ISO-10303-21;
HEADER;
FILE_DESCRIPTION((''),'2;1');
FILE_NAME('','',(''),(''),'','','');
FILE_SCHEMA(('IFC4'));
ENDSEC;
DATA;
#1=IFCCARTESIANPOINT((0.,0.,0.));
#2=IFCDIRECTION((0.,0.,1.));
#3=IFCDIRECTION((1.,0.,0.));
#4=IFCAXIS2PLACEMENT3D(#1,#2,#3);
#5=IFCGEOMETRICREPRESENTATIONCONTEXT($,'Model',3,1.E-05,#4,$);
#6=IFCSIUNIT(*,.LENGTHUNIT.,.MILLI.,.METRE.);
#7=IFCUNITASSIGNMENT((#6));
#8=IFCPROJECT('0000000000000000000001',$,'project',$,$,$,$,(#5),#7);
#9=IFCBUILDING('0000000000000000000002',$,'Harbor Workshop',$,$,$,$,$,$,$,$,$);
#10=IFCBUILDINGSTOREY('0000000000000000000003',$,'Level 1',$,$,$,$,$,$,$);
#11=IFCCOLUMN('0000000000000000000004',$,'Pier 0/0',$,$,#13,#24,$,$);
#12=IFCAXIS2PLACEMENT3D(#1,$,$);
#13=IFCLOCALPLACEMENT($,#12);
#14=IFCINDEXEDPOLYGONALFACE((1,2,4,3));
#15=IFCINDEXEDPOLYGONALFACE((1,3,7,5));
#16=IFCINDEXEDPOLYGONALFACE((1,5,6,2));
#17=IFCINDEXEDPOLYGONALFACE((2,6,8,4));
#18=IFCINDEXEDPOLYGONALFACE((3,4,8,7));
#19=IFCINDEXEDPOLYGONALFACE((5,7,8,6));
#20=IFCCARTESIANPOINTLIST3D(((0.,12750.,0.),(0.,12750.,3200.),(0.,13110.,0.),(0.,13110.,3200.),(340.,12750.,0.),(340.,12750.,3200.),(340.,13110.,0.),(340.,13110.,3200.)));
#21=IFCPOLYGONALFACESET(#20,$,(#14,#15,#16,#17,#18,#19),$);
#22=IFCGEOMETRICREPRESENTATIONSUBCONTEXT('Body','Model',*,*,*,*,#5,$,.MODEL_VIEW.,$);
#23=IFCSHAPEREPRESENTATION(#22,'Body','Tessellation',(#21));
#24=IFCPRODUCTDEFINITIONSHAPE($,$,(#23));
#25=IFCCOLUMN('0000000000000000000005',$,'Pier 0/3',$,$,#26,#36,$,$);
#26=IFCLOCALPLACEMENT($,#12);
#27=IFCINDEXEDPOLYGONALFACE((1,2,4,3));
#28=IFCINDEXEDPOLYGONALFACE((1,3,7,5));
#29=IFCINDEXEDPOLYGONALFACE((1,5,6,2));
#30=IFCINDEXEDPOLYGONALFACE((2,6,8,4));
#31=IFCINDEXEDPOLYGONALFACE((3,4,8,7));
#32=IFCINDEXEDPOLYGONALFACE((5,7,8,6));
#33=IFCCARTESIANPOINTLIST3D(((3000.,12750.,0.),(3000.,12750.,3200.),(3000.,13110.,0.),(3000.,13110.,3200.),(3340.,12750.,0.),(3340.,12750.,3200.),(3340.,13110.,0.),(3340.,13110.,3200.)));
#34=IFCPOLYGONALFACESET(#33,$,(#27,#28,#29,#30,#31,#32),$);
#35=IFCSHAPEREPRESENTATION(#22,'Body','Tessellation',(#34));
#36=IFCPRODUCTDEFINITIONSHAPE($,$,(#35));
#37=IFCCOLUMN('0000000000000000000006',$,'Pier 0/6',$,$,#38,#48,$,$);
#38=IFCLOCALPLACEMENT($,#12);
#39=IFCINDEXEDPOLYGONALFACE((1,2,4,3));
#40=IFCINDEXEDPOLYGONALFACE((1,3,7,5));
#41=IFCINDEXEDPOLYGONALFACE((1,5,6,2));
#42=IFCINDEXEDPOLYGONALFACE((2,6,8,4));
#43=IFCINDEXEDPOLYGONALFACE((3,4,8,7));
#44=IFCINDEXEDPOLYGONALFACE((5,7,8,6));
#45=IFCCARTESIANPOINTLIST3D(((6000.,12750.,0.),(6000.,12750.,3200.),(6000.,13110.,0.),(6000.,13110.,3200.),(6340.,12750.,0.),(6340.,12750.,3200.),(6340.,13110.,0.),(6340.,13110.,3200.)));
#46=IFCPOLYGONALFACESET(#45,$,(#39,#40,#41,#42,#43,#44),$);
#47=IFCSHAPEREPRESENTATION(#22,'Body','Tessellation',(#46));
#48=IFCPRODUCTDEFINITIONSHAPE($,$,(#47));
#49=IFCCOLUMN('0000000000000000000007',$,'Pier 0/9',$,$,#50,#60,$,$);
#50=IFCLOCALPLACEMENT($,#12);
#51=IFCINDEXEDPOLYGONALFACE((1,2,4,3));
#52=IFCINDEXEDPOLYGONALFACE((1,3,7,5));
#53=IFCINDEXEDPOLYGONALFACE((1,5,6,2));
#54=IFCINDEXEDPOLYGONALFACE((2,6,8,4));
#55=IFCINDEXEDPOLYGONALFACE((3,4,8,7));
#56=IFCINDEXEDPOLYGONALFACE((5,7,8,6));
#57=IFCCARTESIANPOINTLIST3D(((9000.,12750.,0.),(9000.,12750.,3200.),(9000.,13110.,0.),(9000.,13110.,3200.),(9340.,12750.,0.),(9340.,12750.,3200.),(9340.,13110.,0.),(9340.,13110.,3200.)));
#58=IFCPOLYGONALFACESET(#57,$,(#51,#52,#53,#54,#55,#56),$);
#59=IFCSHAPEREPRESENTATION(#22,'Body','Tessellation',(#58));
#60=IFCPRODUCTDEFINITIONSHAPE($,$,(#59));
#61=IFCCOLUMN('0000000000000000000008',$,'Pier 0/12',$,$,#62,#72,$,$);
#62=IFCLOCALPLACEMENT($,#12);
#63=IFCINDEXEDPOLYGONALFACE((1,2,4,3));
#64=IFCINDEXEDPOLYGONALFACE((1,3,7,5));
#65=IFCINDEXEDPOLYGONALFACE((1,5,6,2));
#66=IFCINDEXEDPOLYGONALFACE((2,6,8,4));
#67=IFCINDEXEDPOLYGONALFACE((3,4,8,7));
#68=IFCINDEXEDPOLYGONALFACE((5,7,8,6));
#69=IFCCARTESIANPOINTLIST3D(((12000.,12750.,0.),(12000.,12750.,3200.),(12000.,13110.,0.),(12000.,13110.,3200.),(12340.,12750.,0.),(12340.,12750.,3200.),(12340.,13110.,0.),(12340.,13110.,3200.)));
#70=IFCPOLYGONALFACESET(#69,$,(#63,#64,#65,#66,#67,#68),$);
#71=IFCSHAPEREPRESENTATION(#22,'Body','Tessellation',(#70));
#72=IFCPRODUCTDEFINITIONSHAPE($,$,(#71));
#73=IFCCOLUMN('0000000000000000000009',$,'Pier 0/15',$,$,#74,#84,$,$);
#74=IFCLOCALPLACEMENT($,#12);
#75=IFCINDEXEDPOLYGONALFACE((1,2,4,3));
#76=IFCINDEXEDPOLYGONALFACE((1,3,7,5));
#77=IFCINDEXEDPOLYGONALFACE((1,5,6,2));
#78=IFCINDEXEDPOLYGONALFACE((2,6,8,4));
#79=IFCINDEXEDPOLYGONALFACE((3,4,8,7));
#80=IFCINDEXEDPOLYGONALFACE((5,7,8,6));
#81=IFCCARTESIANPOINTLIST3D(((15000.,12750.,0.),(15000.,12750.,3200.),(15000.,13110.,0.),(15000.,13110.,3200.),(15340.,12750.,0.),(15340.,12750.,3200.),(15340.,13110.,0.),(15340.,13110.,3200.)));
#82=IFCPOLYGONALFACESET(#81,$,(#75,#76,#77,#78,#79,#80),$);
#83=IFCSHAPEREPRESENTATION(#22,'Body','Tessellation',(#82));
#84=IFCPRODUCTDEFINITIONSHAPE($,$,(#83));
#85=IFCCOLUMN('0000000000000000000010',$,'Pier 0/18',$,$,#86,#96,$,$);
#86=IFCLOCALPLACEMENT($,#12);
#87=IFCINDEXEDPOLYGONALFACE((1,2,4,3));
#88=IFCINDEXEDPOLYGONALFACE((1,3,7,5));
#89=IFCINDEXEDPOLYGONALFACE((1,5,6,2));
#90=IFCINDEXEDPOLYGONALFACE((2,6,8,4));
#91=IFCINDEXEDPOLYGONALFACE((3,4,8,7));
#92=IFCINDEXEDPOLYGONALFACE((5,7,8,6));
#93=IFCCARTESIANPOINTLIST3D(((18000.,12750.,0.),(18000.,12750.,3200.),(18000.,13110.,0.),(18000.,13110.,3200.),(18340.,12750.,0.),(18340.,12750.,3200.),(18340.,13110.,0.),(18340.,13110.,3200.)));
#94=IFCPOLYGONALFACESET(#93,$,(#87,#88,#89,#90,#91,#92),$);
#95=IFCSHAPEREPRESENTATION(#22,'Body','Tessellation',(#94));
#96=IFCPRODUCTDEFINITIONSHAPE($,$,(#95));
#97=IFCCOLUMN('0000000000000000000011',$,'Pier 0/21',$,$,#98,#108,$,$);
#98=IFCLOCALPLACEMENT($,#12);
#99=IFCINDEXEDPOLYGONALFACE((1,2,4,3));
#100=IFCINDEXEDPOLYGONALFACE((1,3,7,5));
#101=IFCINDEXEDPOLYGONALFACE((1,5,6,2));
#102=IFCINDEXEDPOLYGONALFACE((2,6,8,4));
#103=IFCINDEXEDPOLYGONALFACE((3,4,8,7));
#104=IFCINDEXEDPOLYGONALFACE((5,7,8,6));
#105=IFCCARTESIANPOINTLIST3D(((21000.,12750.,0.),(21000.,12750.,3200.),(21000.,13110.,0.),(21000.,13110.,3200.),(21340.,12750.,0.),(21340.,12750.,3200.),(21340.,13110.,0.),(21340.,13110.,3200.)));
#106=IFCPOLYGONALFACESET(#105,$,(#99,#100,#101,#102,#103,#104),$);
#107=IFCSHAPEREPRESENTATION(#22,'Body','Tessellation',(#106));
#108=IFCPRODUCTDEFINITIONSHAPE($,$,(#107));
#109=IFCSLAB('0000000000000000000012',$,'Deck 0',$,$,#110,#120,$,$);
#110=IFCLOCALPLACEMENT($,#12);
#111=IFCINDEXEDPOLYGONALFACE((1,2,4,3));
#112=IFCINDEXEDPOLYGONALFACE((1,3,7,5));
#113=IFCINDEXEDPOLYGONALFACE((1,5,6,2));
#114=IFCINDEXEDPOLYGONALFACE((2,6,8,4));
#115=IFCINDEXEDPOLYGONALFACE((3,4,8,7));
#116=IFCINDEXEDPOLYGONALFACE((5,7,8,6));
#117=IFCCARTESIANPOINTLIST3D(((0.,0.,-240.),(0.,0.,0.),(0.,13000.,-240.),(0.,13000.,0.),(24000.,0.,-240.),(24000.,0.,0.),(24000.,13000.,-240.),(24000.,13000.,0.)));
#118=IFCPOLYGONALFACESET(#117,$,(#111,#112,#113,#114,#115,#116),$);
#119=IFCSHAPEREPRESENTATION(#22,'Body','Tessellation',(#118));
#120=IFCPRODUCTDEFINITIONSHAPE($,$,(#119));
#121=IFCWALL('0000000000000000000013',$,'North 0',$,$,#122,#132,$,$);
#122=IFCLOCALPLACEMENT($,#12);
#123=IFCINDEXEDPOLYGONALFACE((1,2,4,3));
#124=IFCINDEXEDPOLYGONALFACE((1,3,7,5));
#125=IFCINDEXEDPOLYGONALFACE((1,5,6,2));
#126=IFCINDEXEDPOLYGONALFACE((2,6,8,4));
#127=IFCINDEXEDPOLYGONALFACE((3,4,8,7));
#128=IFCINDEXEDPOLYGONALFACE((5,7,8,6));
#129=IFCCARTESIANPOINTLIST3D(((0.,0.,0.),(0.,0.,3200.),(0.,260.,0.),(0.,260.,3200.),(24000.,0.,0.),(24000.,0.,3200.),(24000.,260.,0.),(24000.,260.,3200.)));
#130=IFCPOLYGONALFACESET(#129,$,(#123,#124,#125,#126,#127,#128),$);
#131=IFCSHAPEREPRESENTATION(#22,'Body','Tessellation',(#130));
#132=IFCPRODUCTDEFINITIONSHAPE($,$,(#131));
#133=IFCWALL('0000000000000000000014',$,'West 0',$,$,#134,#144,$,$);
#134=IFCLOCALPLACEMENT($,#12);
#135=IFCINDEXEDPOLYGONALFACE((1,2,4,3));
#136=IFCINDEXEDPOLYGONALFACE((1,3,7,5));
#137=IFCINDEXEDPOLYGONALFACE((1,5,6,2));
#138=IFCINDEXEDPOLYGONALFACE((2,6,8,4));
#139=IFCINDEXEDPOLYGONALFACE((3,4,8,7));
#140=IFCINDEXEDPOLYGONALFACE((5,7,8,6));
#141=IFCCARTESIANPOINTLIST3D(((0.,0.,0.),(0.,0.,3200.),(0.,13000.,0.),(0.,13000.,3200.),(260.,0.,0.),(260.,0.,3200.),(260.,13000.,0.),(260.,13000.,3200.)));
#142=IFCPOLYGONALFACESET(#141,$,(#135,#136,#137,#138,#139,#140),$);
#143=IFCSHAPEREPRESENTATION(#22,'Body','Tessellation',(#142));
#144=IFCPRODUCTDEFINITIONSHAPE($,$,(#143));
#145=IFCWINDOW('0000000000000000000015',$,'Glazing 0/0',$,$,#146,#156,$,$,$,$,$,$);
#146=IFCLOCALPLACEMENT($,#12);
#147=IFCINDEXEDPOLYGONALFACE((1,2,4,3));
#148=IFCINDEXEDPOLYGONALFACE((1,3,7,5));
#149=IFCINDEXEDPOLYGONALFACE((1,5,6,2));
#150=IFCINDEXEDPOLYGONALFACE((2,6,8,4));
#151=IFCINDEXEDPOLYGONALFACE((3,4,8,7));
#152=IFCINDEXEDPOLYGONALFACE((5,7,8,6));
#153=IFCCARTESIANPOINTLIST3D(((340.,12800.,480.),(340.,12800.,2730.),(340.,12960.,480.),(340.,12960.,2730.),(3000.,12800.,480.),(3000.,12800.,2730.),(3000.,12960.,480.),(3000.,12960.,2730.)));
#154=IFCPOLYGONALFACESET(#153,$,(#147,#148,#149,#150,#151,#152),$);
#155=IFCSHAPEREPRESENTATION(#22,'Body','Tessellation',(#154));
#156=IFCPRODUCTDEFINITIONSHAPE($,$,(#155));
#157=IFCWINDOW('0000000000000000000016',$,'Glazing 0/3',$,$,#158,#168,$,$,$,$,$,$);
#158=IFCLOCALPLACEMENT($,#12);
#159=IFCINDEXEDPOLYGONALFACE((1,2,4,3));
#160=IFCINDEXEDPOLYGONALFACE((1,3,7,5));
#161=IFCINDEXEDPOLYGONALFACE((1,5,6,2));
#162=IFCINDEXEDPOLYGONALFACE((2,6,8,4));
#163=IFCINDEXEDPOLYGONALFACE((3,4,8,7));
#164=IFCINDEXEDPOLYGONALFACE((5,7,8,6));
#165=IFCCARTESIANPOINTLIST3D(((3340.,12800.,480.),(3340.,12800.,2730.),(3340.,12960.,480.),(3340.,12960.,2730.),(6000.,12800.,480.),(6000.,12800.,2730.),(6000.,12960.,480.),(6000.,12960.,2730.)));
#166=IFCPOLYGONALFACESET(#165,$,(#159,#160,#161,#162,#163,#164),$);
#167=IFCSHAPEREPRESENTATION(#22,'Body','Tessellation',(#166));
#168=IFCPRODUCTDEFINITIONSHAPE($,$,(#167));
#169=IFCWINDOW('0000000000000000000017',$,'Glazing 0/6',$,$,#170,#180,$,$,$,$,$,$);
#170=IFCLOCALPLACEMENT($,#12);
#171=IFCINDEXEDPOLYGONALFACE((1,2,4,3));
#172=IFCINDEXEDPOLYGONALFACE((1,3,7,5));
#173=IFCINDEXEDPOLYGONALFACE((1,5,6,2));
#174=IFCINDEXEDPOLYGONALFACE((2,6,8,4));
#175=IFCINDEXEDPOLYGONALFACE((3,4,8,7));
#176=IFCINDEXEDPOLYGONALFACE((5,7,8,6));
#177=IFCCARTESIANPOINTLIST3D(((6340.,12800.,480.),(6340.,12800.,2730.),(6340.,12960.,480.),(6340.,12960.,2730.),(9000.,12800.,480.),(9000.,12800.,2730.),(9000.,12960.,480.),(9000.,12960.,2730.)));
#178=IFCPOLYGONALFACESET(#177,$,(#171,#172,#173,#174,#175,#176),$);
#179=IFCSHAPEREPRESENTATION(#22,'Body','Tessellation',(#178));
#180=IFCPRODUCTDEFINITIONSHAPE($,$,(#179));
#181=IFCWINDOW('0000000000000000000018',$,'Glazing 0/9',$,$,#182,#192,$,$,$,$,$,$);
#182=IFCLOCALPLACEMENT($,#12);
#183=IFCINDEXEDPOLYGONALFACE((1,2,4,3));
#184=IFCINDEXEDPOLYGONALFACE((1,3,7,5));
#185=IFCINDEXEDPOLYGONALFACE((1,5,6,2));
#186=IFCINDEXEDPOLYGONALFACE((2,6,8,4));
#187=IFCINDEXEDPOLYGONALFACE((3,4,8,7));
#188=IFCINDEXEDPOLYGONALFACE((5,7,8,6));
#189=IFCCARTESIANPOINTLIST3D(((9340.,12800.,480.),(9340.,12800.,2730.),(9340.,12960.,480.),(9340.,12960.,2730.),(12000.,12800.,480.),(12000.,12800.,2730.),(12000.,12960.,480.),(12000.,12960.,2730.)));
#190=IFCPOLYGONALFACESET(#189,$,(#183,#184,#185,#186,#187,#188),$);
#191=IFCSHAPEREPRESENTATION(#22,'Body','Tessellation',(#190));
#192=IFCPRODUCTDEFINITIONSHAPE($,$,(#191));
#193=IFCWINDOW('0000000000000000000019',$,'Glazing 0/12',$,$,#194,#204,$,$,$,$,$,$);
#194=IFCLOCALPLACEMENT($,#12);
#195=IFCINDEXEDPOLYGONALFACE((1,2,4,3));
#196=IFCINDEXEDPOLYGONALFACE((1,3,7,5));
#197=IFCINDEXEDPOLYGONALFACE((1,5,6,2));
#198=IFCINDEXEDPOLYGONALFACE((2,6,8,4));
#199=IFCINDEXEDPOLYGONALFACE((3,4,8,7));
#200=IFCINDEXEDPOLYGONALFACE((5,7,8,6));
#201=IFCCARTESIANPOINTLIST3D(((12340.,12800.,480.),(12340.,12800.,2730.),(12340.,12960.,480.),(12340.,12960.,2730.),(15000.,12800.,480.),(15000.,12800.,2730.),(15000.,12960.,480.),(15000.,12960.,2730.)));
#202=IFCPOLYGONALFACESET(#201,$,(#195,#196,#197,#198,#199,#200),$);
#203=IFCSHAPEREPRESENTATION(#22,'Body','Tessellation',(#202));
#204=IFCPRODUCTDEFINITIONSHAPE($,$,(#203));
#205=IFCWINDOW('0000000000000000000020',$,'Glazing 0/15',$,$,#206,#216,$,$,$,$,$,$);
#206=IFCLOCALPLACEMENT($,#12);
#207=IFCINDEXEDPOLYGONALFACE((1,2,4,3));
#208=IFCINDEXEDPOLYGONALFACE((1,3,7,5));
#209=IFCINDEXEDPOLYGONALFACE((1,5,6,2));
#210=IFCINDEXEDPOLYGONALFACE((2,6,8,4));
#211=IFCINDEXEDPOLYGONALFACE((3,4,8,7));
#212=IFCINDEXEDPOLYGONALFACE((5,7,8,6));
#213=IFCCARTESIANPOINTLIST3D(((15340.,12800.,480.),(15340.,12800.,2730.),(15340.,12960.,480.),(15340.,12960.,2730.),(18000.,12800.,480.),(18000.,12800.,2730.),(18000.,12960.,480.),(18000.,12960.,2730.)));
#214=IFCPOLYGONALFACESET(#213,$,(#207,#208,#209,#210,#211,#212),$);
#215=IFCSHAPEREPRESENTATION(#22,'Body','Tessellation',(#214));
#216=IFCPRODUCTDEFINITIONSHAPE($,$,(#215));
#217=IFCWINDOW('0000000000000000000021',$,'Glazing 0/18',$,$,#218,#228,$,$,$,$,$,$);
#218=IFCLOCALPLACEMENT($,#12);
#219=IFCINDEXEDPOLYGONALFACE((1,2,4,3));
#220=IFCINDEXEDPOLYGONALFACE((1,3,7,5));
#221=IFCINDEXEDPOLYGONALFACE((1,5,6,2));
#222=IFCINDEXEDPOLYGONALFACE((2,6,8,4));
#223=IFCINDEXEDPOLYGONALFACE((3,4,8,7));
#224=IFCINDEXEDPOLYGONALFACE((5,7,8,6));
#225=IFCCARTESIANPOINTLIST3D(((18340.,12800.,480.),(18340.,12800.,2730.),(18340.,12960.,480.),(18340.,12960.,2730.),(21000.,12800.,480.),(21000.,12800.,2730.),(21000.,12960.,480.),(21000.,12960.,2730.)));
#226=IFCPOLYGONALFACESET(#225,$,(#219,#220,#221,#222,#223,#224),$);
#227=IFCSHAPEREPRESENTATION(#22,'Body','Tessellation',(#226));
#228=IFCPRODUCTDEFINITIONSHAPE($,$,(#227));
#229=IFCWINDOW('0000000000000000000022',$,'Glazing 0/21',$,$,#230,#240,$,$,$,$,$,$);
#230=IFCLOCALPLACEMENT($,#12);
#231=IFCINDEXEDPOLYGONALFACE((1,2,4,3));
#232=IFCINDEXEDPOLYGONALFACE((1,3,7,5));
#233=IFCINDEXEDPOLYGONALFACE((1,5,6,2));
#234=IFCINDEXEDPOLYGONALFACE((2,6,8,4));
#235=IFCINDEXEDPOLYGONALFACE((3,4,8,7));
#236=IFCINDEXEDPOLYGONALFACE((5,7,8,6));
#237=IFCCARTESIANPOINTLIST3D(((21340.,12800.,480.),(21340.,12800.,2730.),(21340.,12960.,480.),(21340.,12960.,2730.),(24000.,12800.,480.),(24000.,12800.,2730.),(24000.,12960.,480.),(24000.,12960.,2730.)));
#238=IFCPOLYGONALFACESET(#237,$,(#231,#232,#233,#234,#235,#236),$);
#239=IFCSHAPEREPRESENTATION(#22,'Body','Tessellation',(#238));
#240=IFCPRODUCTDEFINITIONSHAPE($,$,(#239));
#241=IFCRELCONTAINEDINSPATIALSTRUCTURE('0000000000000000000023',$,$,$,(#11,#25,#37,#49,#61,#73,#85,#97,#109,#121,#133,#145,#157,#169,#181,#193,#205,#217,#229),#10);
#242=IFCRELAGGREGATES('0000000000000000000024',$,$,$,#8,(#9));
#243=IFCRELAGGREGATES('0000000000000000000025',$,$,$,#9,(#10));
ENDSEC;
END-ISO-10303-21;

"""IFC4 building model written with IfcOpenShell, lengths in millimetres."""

from ifc_helpers import new_model, si_unit, frame, origin_with_axes, place, context, subcontext, project, spatial, indexed_curve, outline, extrude, element, save


model = new_model("IFC4")

# Units and contexts
model_context = context("Model", 3, precision=1e-05, world=origin_with_axes())
body_context = subcontext(model_context, "Body", "Model", "MODEL_VIEW")
ifc_project = project(units=[si_unit("LENGTHUNIT", "METRE", prefix="MILLI")], contexts=[model_context])

# Building, storey
building = spatial("IfcBuilding", under=ifc_project, Name="Harbor Workshop")
storey = spatial("IfcBuildingStorey", under=building, Name="Level 1")

# Columns
for number, where, z_axis, x_axis, name in (
    (1, (0.0, 12750.0, 0.0), (0.0, 0.0, 1.0), (1.0, 0.0, 0.0), "Pier 0/0"),
    (2, (3000.0, 12750.0, 0.0), (0.0, 0.0, 1.0), (1.0, 0.0, 0.0), "Pier 0/3"),
    (3, (6000.0, 12750.0, 0.0), (0.0, 0.0, 1.0), (1.0, 0.0, 0.0), "Pier 0/6"),
    (4, (9000.0, 12750.0, 0.0), (0.0, 0.0, 1.0), (1.0, 0.0, 0.0), "Pier 0/9"),
    (5, (12000.0, 12750.0, 0.0), (0.0, 0.0, 1.0), (1.0, 0.0, 0.0), "Pier 0/12"),
    (6, (15000.0, 12750.0, 0.0), (0.0, 0.0, 1.0), (1.0, 0.0, 0.0), "Pier 0/15"),
    (7, (18000.0, 12750.0, 0.0), (0.0, 0.0, 1.0), (1.0, 0.0, 0.0), "Pier 0/18"),
    (8, (21000.0, 12750.0, 0.0), (0.0, 0.0, 1.0), (1.0, 0.0, 0.0), "Pier 0/21"),
):
    element("IfcColumn", number, at=place(None, frame(where, z_axis=z_axis, x_axis=x_axis)), inside=storey, Name=name, context=body_context, shape_type="SweptSolid", body=[
        extrude(outline(indexed_curve([(0.0, 0.0), (0.0, 360.0), (340.0, 360.0), (340.0, 0.0), (0.0, 0.0)], self_intersect=False)), origin_with_axes(), (0.0, 0.0, 1.0), 3200.0),
    ])

# Slab
slab_placement = place(None, frame((0.0, 0.0, -240.0), z_axis=(0.0, 0.0, 1.0), x_axis=(1.0, 0.0, 0.0)))
element("IfcSlab", 9, at=slab_placement, inside=storey, Name="Deck 0", context=body_context, shape_type="SweptSolid", body=[
    extrude(outline(indexed_curve([(0.0, 0.0), (0.0, 13000.0), (24000.0, 13000.0), (24000.0, 0.0), (0.0, 0.0)], self_intersect=False)), origin_with_axes(), (0.0, 0.0, 1.0), 240.0),
])

# Walls
wall_1_placement = place(None, origin_with_axes())
element("IfcWall", 10, at=wall_1_placement, inside=storey, Name="North 0", context=body_context, shape_type="SweptSolid", body=[
    extrude(outline(indexed_curve([(0.0, 0.0), (0.0, 260.0), (24000.0, 260.0), (24000.0, 0.0), (0.0, 0.0)], self_intersect=False)), origin_with_axes(), (0.0, 0.0, 1.0), 3200.0),
])
wall_2_placement = place(None, frame((260.0, 0.0, 0.0), z_axis=(0.0, 0.0, 1.0), x_axis=(0.0, 1.0, 0.0)))
element("IfcWall", 11, at=wall_2_placement, inside=storey, Name="West 0", context=body_context, shape_type="SweptSolid", body=[
    extrude(outline(indexed_curve([(0.0, 0.0), (0.0, 260.0), (13000.0, 260.0), (13000.0, 0.0), (0.0, 0.0)], self_intersect=False)), origin_with_axes(), (0.0, 0.0, 1.0), 3200.0),
])

# Windows
for number, where, z_axis, x_axis, name in (
    (12, (340.0, 12800.0, 480.0), (0.0, 0.0, 1.0), (1.0, 0.0, 0.0), "Glazing 0/0"),
    (13, (3340.0, 12800.0, 480.0), (0.0, 0.0, 1.0), (1.0, 0.0, 0.0), "Glazing 0/3"),
    (14, (6340.0, 12800.0, 480.0), (0.0, 0.0, 1.0), (1.0, 0.0, 0.0), "Glazing 0/6"),
    (15, (9340.0, 12800.0, 480.0), (0.0, 0.0, 1.0), (1.0, 0.0, 0.0), "Glazing 0/9"),
    (16, (12340.0, 12800.0, 480.0), (0.0, 0.0, 1.0), (1.0, 0.0, 0.0), "Glazing 0/12"),
    (17, (15340.0, 12800.0, 480.0), (0.0, 0.0, 1.0), (1.0, 0.0, 0.0), "Glazing 0/15"),
    (18, (18340.0, 12800.0, 480.0), (0.0, 0.0, 1.0), (1.0, 0.0, 0.0), "Glazing 0/18"),
    (19, (21340.0, 12800.0, 480.0), (0.0, 0.0, 1.0), (1.0, 0.0, 0.0), "Glazing 0/21"),
):
    element("IfcWindow", number, at=place(None, frame(where, z_axis=z_axis, x_axis=x_axis)), inside=storey, Name=name, context=body_context, shape_type="SweptSolid", body=[
        extrude(outline(indexed_curve([(0.0, 0.0), (0.0, 160.0), (2660.0, 160.0), (2660.0, 0.0), (0.0, 0.0)], self_intersect=False)), origin_with_axes(), (0.0, 0.0, 1.0), 2250.0),
    ])

save(model, "model.ifc")
